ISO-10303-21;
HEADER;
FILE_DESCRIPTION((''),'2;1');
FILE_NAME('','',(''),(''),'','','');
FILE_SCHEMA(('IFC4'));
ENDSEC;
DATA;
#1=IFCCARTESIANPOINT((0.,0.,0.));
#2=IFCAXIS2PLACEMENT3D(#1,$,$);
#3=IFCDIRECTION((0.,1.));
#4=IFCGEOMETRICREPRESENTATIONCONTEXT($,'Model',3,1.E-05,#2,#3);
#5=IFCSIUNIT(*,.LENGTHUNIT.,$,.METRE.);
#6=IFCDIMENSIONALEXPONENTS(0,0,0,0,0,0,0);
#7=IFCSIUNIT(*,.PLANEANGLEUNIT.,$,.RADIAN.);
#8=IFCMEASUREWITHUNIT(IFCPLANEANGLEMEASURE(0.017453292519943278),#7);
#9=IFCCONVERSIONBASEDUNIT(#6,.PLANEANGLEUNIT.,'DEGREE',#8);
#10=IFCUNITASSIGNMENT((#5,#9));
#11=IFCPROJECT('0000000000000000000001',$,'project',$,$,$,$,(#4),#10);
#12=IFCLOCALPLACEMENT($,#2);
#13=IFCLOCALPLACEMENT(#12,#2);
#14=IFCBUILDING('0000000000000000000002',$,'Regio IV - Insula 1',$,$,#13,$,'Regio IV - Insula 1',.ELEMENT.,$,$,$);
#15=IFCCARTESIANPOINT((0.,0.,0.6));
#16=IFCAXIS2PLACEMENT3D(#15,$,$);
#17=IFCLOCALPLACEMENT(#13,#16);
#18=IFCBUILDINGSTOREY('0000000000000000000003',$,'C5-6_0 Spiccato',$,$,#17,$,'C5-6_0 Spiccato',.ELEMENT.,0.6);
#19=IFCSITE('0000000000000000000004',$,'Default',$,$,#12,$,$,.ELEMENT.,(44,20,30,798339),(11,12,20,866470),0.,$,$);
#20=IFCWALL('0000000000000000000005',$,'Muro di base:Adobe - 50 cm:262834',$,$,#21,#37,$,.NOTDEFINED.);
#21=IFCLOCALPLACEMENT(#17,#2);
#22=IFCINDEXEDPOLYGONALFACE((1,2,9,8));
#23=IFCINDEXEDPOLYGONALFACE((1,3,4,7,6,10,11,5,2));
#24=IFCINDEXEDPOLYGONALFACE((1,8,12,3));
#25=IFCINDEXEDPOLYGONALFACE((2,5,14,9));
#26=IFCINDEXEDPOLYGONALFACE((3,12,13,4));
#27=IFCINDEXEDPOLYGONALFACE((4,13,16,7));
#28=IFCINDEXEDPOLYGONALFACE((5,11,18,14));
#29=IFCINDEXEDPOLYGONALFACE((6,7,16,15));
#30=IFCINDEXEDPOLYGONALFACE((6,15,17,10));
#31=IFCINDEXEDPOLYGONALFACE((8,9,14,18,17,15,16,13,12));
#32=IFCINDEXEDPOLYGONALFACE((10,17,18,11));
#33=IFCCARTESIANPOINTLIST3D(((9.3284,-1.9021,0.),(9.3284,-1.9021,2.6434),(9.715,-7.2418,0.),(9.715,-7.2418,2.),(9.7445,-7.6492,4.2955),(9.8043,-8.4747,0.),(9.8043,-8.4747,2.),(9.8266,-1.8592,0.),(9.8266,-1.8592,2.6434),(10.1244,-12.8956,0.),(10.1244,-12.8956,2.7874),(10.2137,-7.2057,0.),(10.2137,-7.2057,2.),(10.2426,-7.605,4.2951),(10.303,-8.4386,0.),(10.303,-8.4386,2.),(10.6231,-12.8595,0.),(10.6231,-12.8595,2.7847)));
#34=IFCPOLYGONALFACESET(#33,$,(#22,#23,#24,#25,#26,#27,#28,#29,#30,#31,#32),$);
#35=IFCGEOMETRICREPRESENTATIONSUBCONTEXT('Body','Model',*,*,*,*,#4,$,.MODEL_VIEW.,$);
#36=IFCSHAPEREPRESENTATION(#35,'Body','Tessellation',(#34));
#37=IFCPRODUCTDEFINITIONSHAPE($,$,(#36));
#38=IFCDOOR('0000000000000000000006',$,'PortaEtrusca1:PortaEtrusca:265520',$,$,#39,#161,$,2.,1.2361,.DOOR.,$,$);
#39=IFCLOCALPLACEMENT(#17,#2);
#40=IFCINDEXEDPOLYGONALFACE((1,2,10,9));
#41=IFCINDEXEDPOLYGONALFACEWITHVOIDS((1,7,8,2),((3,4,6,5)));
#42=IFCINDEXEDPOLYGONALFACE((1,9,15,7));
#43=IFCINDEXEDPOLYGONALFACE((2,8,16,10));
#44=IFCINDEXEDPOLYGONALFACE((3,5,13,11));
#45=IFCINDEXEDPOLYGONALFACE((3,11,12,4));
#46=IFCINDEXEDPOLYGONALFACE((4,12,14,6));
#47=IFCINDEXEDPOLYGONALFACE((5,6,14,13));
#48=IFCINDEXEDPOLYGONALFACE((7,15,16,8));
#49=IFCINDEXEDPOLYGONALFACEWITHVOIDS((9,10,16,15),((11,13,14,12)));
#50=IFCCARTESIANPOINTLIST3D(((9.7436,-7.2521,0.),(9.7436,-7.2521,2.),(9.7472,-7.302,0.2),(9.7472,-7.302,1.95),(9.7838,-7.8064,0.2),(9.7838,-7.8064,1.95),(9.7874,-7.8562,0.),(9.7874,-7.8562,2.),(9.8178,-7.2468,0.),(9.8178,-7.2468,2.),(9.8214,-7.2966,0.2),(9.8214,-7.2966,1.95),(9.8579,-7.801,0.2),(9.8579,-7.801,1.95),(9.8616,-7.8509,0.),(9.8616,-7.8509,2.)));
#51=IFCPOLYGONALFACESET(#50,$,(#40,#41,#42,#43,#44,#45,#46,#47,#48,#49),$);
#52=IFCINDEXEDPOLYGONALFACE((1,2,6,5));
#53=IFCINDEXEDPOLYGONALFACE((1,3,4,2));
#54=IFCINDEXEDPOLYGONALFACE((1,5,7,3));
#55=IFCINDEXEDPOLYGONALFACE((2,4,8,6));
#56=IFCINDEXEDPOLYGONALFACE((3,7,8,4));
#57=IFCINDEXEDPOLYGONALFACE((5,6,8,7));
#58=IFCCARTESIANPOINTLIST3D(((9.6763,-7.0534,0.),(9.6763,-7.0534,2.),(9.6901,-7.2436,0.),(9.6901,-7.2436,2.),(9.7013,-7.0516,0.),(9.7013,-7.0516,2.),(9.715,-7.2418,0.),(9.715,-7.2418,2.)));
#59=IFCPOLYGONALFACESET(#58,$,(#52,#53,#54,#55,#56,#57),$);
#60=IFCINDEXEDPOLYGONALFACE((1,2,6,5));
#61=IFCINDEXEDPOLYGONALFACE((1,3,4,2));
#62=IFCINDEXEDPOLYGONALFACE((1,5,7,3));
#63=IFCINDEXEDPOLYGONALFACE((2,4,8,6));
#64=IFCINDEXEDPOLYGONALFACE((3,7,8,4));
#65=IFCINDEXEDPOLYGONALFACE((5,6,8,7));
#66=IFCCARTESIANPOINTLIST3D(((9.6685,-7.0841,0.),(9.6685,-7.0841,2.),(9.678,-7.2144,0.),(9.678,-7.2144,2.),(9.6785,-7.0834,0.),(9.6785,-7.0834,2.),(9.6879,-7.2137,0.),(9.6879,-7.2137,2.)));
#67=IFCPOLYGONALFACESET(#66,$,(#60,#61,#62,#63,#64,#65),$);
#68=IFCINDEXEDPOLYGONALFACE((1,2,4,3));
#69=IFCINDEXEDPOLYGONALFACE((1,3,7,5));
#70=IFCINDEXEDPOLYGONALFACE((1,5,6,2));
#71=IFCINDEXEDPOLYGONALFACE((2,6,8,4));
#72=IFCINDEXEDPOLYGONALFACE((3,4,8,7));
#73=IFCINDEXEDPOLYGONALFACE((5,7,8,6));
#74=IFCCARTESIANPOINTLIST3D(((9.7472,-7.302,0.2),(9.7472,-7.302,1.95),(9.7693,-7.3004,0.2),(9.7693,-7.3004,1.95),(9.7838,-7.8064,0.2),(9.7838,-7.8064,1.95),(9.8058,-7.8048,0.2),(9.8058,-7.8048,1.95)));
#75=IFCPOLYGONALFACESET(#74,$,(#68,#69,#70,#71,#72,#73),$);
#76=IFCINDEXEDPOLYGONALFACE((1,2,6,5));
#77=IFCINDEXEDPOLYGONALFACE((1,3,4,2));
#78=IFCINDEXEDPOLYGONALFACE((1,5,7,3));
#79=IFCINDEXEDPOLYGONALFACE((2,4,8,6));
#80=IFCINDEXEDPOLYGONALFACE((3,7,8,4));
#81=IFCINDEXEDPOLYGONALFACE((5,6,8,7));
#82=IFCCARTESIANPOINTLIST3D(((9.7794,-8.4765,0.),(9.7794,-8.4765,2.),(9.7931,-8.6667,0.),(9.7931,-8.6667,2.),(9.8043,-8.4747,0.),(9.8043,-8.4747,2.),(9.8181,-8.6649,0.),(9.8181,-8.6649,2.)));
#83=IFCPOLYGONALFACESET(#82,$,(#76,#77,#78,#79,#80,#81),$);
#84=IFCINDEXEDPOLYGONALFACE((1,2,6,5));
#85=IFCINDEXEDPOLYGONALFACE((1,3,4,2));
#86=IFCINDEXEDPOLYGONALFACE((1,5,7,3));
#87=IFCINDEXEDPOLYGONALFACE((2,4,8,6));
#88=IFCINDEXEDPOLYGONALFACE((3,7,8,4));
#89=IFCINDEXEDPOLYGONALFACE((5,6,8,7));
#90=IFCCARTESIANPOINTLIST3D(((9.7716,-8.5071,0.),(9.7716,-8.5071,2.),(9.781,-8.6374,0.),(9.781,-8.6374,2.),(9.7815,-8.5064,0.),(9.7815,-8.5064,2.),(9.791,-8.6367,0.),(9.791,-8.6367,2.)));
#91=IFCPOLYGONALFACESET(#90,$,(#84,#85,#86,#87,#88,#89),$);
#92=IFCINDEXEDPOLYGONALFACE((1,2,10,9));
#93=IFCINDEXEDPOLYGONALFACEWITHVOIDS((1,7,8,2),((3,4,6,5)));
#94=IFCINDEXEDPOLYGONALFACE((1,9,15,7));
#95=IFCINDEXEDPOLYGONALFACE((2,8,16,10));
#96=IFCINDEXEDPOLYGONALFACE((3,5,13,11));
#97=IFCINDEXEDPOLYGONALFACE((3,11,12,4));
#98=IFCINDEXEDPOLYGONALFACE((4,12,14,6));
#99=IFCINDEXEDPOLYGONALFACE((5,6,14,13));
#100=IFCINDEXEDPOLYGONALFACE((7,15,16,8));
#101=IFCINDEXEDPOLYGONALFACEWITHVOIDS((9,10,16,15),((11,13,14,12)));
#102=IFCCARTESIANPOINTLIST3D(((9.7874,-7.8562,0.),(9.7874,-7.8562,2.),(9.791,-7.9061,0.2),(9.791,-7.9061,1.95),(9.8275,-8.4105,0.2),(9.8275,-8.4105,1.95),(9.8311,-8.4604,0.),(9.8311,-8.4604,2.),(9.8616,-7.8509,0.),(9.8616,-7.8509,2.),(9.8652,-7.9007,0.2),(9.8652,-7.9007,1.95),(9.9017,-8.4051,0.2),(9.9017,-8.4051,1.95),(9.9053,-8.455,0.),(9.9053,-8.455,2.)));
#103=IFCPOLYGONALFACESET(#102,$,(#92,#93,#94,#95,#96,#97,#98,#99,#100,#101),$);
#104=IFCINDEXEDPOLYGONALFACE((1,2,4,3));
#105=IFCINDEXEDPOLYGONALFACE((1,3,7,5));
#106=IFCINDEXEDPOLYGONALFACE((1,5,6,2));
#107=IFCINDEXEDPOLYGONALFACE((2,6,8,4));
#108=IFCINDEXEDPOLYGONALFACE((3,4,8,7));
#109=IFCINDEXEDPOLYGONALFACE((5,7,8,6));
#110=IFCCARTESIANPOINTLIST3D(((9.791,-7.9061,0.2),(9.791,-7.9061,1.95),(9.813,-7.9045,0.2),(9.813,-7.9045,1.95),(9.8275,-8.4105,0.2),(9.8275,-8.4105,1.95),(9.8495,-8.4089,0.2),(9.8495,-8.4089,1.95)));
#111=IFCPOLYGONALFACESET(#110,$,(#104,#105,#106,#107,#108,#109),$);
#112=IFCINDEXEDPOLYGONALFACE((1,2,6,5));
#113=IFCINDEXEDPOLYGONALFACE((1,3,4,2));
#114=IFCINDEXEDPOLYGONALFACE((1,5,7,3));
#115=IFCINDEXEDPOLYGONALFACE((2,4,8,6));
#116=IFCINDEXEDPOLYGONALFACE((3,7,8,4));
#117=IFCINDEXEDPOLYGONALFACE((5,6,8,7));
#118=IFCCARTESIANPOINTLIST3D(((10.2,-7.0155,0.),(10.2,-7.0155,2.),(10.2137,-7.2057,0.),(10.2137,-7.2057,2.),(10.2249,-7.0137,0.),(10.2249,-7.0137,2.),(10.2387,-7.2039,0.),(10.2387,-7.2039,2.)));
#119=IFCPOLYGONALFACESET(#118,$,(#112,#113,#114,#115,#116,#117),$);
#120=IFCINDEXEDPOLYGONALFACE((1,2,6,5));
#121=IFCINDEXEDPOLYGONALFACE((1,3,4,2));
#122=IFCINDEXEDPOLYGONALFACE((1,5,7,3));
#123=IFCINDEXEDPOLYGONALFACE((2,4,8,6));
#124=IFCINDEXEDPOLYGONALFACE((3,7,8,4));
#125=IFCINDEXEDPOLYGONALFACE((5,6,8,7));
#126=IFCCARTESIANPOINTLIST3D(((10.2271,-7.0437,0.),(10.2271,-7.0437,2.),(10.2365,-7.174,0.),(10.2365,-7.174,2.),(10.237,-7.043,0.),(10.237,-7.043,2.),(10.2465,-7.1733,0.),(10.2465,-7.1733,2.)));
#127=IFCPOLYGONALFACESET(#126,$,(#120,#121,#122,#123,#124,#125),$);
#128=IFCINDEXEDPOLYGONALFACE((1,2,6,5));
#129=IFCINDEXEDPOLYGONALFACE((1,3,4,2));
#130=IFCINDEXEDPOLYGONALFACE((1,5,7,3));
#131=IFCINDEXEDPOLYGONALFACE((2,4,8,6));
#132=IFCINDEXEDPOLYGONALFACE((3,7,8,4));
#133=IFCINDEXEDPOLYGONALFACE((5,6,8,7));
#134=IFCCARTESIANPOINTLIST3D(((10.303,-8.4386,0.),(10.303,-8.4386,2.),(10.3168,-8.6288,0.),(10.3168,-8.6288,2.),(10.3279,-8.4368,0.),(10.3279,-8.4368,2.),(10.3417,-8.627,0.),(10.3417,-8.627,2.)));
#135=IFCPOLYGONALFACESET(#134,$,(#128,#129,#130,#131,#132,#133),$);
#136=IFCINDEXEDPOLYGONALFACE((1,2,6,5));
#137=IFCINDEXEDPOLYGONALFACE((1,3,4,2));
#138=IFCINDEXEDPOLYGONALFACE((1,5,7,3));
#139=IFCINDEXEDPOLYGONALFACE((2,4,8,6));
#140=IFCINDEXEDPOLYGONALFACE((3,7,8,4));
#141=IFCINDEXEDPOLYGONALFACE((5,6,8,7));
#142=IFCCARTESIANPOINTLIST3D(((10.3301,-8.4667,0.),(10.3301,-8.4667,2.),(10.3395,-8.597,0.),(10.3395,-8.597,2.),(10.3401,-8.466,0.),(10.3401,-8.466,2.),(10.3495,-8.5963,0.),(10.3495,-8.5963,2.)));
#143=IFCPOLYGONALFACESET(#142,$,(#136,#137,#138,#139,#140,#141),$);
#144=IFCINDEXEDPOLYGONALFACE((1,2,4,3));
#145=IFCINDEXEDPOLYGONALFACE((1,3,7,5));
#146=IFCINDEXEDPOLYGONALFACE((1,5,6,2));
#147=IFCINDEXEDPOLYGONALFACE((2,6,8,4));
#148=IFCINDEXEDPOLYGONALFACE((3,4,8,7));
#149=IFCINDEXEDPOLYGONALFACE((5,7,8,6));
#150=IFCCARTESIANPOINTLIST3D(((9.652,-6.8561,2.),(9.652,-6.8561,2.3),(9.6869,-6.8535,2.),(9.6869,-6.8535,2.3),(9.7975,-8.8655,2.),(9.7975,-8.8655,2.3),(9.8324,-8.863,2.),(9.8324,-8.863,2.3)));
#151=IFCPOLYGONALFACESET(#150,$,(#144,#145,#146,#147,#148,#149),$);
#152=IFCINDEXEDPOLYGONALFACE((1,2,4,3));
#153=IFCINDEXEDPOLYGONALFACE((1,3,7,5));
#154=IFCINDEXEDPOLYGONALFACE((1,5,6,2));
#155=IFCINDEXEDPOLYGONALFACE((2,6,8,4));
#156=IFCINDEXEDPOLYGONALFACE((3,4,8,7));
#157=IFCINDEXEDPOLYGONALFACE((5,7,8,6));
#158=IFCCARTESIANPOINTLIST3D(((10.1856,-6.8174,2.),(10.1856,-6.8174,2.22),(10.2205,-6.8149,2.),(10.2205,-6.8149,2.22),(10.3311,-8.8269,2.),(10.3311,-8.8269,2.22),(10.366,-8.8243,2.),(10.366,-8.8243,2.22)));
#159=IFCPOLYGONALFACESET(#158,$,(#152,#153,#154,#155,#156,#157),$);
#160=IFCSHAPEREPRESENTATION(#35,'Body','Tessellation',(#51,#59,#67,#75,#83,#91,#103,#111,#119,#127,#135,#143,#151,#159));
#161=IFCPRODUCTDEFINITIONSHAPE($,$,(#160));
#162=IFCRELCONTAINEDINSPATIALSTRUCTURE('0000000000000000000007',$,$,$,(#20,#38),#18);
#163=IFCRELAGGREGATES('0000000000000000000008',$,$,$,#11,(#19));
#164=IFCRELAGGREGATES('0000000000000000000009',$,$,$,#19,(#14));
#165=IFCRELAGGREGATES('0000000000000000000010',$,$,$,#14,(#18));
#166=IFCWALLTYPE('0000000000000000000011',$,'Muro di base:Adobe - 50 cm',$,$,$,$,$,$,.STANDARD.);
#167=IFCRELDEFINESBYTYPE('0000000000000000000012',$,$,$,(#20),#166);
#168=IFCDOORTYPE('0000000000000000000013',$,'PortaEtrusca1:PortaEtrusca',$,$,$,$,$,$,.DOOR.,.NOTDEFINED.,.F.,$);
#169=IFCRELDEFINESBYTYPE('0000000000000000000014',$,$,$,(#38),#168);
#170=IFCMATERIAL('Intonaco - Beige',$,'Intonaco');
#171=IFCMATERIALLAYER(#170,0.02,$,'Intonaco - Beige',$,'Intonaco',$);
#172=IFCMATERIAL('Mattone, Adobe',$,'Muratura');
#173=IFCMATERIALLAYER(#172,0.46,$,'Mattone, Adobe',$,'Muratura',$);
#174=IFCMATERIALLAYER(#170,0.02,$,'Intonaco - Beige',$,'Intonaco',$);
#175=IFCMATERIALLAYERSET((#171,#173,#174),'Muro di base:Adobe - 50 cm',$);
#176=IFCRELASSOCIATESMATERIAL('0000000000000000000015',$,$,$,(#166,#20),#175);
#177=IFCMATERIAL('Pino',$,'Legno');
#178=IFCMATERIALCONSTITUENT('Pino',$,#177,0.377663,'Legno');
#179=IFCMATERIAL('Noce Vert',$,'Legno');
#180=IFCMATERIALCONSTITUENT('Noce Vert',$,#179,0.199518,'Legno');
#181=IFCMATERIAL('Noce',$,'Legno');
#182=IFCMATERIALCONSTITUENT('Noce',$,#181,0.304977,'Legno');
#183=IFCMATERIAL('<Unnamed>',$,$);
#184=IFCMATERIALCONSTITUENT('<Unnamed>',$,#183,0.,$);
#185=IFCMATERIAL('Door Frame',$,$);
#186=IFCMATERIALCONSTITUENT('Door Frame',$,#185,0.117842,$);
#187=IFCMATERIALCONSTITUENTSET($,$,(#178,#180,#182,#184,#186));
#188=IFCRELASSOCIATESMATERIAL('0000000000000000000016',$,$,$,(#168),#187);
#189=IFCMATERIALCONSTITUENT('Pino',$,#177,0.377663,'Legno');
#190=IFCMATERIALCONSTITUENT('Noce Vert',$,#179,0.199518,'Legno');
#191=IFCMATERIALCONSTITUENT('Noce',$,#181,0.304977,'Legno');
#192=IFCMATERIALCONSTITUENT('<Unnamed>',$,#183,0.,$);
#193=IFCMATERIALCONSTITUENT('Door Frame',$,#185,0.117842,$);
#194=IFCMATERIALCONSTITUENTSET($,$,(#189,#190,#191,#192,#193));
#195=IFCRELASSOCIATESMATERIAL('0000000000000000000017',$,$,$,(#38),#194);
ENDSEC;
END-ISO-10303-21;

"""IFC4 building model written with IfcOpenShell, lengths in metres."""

from ifc_helpers import new_model, entity, si_unit, converted_unit, direction, frame, frame_2d, origin, origin_2d_with_axis, place, context, subcontext, project, spatial, polyline, rectangle, outline, extrude, clip, bounded_halfspace, source, transform, mapped, material, layer, layer_set, layer_usage, constituent, constituent_set, type_object, type_shapes, element, fill, save


model = new_model("IFC4")

# Units and contexts
model_context = context("Model", 3, precision=1e-05, world=origin(), true_north=direction((0.0, 1.0)))
body_context = subcontext(model_context, "Body", "Model", "MODEL_VIEW")
ifc_project = project(units=[si_unit("LENGTHUNIT", "METRE"), converted_unit("PLANEANGLEUNIT", "DEGREE", entity("IfcPlaneAngleMeasure", 0.017453292519943278), si_unit("PLANEANGLEUNIT", "RADIAN"), dimensions=[0, 0, 0, 0, 0, 0, 0])], contexts=[model_context])

# Site, building, storey
site_placement = place(None, origin())
site = spatial("IfcSite", under=ifc_project, at=site_placement, Name="Default", CompositionType="ELEMENT", RefLatitude=(44, 20, 30, 798339), RefLongitude=(11, 12, 20, 866470), RefElevation=0.0)
building_placement = place(site_placement, origin())
building = spatial("IfcBuilding", under=site, at=building_placement, Name="Regio IV - Insula 1", LongName="Regio IV - Insula 1", CompositionType="ELEMENT")
storey_placement = place(building_placement, frame((0.0, 0.0, 0.6)))
storey = spatial("IfcBuildingStorey", under=building, at=storey_placement, Name="C5-6_0 Spiccato", LongName="C5-6_0 Spiccato", CompositionType="ELEMENT", Elevation=0.6)

# Shared definitions
ifc_material_1 = material(Name="Intonaco - Beige", Category="Intonaco")
ifc_material_2 = material(Name="Mattone, Adobe", Category="Muratura")
ifc_layer_1 = layer(ifc_material_1, 0.02, Name="Intonaco - Beige", Category="Intonaco")
ifc_layer_2 = layer(ifc_material_2, 0.46, Name="Mattone, Adobe", Category="Muratura")
ifc_layer_3 = layer(ifc_material_1, 0.02, Name="Intonaco - Beige", Category="Intonaco")
ifc_layer_set_1 = layer_set([ifc_layer_1, ifc_layer_2, ifc_layer_3], Name="Muro di base:Adobe - 50 cm")
wall_type_1 = type_object("IfcWallType", Name="Muro di base:Adobe - 50 cm", PredefinedType="STANDARD", material=ifc_layer_set_1)

# Shared definitions
ifc_material_3 = material(Name="Pino", Category="Legno")
ifc_material_4 = material(Name="Noce Vert", Category="Legno")
ifc_material_5 = material(Name="Noce", Category="Legno")
ifc_material_6 = material(Name="<Unnamed>")
ifc_material_7 = material(Name="Door Frame")
ifc_constituent_1 = constituent(ifc_material_3, Name="Pino", Category="Legno", fraction=0.377663)
ifc_constituent_2 = constituent(ifc_material_4, Name="Noce Vert", Category="Legno", fraction=0.199518)
ifc_constituent_3 = constituent(ifc_material_5, Name="Noce", Category="Legno", fraction=0.304977)
ifc_constituent_4 = constituent(ifc_material_6, Name="<Unnamed>", fraction=0.0)
ifc_constituent_5 = constituent(ifc_material_7, Name="Door Frame", fraction=0.117842)
ifc_constituent_set_1 = constituent_set(constituents=[ifc_constituent_1, ifc_constituent_2, ifc_constituent_3, ifc_constituent_4, ifc_constituent_5])
door_type = type_object("IfcDoorType", Name="PortaEtrusca1:PortaEtrusca", OperationType="NOTDEFINED", ParameterTakesPrecedence=False, PredefinedType="DOOR", material=ifc_constituent_set_1)
shared_shape = source(origin(), body_context, "Body", "SweptSolid", [
    extrude(outline(polyline([(-1.0, -0.3028), (1.0, -0.3028), (1.0, 0.3028), (-1.0, 0.3028), (-1.0, -0.3028)]), holes=[polyline([(-0.95, 0.2528), (0.8, 0.2528), (0.8, -0.2528), (-0.95, -0.2528), (-0.95, 0.2528)])]), frame((0.3152, 0.0278, 1.0), z_axis=(0.0, 1.0, 0.0), x_axis=(0.0, 0.0, -1.0)), (0.0, 0.0, 1.0), 0.0744),
    extrude(rectangle(XDim=0.025, YDim=0.1907, at=frame_2d((0.0, 0.0), x_axis=(1.0, 0.0))), frame((-0.0953, -0.0125, 0.0), z_axis=(0.0, 0.0, 1.0), x_axis=(0.0, 1.0, 0.0)), (0.0, 0.0, 1.0), 2.0),
    extrude(rectangle(XDim=0.01, YDim=0.1306, at=frame_2d((0.0, 0.0), x_axis=(1.0, 0.0))), frame((-0.0953, -0.03, 0.0), z_axis=(0.0, 0.0, 1.0), x_axis=(0.0, 1.0, 0.0)), (0.0, 0.0, 1.0), 2.0),
    extrude(rectangle(XDim=0.0221, YDim=0.5057, at=frame_2d((0.0, 0.0), x_axis=(1.0, 0.0))), frame((0.3152, 0.0388, 0.2), z_axis=(0.0, 0.0, 1.0), x_axis=(0.0, 1.0, 0.0)), (0.0, 0.0, 1.0), 1.75),
    extrude(rectangle(XDim=0.025, YDim=0.1907, at=frame_2d((0.0, 0.0), x_axis=(1.0, 0.0))), frame((1.3314, -0.0125, 0.0), z_axis=(0.0, 0.0, 1.0), x_axis=(0.0, 1.0, 0.0)), (0.0, 0.0, 1.0), 2.0),
    extrude(rectangle(XDim=0.01, YDim=0.1306, at=frame_2d((0.0, 0.0), x_axis=(1.0, 0.0))), frame((1.3314, -0.03, 0.0), z_axis=(0.0, 0.0, 1.0), x_axis=(0.0, 1.0, 0.0)), (0.0, 0.0, 1.0), 2.0),
    extrude(outline(polyline([(-0.3028, -1.0), (0.3028, -1.0), (0.3028, 1.0), (-0.3028, 1.0), (-0.3028, -1.0)]), holes=[polyline([(0.2528, -0.95), (-0.2528, -0.95), (-0.2528, 0.8), (0.2528, 0.8), (0.2528, -0.95)])]), frame((0.9209, 0.0278, 1.0), z_axis=(0.0, 1.0, 0.0), x_axis=(1.0, 0.0, 0.0)), (0.0, 0.0, 1.0), 0.0744),
    extrude(rectangle(XDim=0.0221, YDim=0.5057, at=frame_2d((0.0, 0.0), x_axis=(1.0, 0.0))), frame((0.9209, 0.0388, 0.2), z_axis=(0.0, 0.0, 1.0), x_axis=(0.0, 1.0, 0.0)), (0.0, 0.0, 1.0), 1.75),
    extrude(rectangle(XDim=0.025, YDim=0.1907, at=frame_2d((0.0, 0.0), x_axis=(1.0, 0.0))), frame((-0.0953, 0.5125, 0.0), z_axis=(0.0, 0.0, 1.0), x_axis=(0.0, -1.0, 0.0)), (0.0, 0.0, 1.0), 2.0),
    extrude(rectangle(XDim=0.01, YDim=0.1306, at=frame_2d((0.0, 0.0), x_axis=(1.0, 0.0))), frame((-0.0953, 0.53, 0.0), z_axis=(0.0, 0.0, 1.0), x_axis=(0.0, -1.0, 0.0)), (0.0, 0.0, 1.0), 2.0),
    extrude(rectangle(XDim=0.025, YDim=0.1907, at=frame_2d((0.0, 0.0), x_axis=(1.0, 0.0))), frame((1.3314, 0.5125, 0.0), z_axis=(0.0, 0.0, 1.0), x_axis=(0.0, -1.0, 0.0)), (0.0, 0.0, 1.0), 2.0),
    extrude(rectangle(XDim=0.01, YDim=0.1306, at=frame_2d((0.0, 0.0), x_axis=(1.0, 0.0))), frame((1.3314, 0.53, 0.0), z_axis=(0.0, 0.0, 1.0), x_axis=(0.0, -1.0, 0.0)), (0.0, 0.0, 1.0), 2.0),
    extrude(rectangle(XDim=0.035, YDim=2.0147, at=origin_2d_with_axis()), frame((0.618, -0.0175, 2.0), z_axis=(0.0, 0.0, 1.0), x_axis=(0.0, 1.0, 0.0)), (0.0, 0.0, 1.0), 0.3),
    extrude(rectangle(XDim=0.035, YDim=2.0147, at=origin_2d_with_axis()), frame((0.618, 0.5175, 2.0), z_axis=(0.0, 0.0, 1.0), x_axis=(0.0, -1.0, 0.0)), (0.0, 0.0, 1.0), 0.22),
])
type_shapes(door_type, [shared_shape])

# Wall, opening, door
ifc_layer_usage_1 = layer_usage(ifc_layer_set_1, "AXIS2", "NEGATIVE", 0.25)
wall_1_placement = place(storey_placement, frame((10.3738, -12.8776, 0.0), z_axis=(0.0, 0.0, 1.0), x_axis=(-0.07222, 0.997389, 0.0)))
wall_1 = element("IfcWall", 1, at=wall_1_placement, inside=storey, type_object=wall_type_1, material=ifc_layer_usage_1, Name="Muro di base:Adobe - 50 cm:262834", PredefinedType="NOTDEFINED", context=body_context, shape_type="Clipping", body=[
    clip(clip(extrude(outline(polyline([(0.0, -0.25), (11.0291, -0.25), (11.0223, 0.25), (0.0, 0.25), (0.0, -0.25)])), origin(), (0.0, 0.0, 1.0), 4.2955), bounded_halfspace(frame((11.0291, -0.25, 2.6434), z_axis=(0.275612, 0.003755, 0.961262), x_axis=(-0.013623, 0.999907, 0.0)), False, frame((11.0291, -0.25, 2.6434)), polyline([(0.0, 0.0), (-0.0068, 0.5), (-5.7689, 0.5), (-5.7608, 0.0), (-4.7785, 0.0), (-4.1785, 0.0), (0.0, 0.0)]))), bounded_halfspace(frame((0.0, 0.25, 2.7874), z_axis=(-0.275589, -0.005177, 0.961262), x_axis=(0.018783, -0.999824, 0.0)), False, frame((0.0, 0.25, 2.7874)), polyline([(0.0, 0.0), (0.0, -0.5), (3.5777, -0.5), (4.0778, -0.5), (5.2683, -0.5), (5.2602, 0.0), (0.0, 0.0)]))),
])
opening_1_placement = place(wall_1_placement, frame((5.6686, 0.25, 0.0)))
opening_1 = element("IfcOpeningElement", 2, at=opening_1_placement, cuts=wall_1, PredefinedType="OPENING", context=body_context, shape_type="SweptSolid", body=[
    extrude(rectangle(XDim=2.0, YDim=1.2361, at=frame_2d((1.0, 0.618), x_axis=(1.0, 0.0))), frame((0.0, 0.0, 0.0), z_axis=(0.0, -1.0, 0.0), x_axis=(0.0, 0.0, 1.0)), (0.0, 0.0, 1.0), 0.5),
])
ifc_constituent_6 = constituent(ifc_material_3, Name="Pino", Category="Legno", fraction=0.377663)
ifc_constituent_7 = constituent(ifc_material_4, Name="Noce Vert", Category="Legno", fraction=0.199518)
ifc_constituent_8 = constituent(ifc_material_5, Name="Noce", Category="Legno", fraction=0.304977)
ifc_constituent_9 = constituent(ifc_material_6, Name="<Unnamed>", fraction=0.0)
ifc_constituent_10 = constituent(ifc_material_7, Name="Door Frame", fraction=0.117842)
ifc_constituent_set_2 = constituent_set(constituents=[ifc_constituent_6, ifc_constituent_7, ifc_constituent_8, ifc_constituent_9, ifc_constituent_10])
door_1_placement = place(opening_1_placement, frame((0.0, 0.0, 0.0), z_axis=(0.0, 0.0, 1.0), x_axis=(-1.0, 0.0, 0.0)))
door_1 = element("IfcDoor", 3, at=door_1_placement, inside=storey, type_object=door_type, material=ifc_constituent_set_2, Name="PortaEtrusca1:PortaEtrusca:265520", OverallHeight=2.0, OverallWidth=1.2361, PredefinedType="DOOR", context=body_context, shape_type="MappedRepresentation", body=[
    mapped(shared_shape, transform((0.0, 0.0, 0.0), scale=1.0)),
])
fill(opening_1, door_1)

save(model, "model.ifc")
